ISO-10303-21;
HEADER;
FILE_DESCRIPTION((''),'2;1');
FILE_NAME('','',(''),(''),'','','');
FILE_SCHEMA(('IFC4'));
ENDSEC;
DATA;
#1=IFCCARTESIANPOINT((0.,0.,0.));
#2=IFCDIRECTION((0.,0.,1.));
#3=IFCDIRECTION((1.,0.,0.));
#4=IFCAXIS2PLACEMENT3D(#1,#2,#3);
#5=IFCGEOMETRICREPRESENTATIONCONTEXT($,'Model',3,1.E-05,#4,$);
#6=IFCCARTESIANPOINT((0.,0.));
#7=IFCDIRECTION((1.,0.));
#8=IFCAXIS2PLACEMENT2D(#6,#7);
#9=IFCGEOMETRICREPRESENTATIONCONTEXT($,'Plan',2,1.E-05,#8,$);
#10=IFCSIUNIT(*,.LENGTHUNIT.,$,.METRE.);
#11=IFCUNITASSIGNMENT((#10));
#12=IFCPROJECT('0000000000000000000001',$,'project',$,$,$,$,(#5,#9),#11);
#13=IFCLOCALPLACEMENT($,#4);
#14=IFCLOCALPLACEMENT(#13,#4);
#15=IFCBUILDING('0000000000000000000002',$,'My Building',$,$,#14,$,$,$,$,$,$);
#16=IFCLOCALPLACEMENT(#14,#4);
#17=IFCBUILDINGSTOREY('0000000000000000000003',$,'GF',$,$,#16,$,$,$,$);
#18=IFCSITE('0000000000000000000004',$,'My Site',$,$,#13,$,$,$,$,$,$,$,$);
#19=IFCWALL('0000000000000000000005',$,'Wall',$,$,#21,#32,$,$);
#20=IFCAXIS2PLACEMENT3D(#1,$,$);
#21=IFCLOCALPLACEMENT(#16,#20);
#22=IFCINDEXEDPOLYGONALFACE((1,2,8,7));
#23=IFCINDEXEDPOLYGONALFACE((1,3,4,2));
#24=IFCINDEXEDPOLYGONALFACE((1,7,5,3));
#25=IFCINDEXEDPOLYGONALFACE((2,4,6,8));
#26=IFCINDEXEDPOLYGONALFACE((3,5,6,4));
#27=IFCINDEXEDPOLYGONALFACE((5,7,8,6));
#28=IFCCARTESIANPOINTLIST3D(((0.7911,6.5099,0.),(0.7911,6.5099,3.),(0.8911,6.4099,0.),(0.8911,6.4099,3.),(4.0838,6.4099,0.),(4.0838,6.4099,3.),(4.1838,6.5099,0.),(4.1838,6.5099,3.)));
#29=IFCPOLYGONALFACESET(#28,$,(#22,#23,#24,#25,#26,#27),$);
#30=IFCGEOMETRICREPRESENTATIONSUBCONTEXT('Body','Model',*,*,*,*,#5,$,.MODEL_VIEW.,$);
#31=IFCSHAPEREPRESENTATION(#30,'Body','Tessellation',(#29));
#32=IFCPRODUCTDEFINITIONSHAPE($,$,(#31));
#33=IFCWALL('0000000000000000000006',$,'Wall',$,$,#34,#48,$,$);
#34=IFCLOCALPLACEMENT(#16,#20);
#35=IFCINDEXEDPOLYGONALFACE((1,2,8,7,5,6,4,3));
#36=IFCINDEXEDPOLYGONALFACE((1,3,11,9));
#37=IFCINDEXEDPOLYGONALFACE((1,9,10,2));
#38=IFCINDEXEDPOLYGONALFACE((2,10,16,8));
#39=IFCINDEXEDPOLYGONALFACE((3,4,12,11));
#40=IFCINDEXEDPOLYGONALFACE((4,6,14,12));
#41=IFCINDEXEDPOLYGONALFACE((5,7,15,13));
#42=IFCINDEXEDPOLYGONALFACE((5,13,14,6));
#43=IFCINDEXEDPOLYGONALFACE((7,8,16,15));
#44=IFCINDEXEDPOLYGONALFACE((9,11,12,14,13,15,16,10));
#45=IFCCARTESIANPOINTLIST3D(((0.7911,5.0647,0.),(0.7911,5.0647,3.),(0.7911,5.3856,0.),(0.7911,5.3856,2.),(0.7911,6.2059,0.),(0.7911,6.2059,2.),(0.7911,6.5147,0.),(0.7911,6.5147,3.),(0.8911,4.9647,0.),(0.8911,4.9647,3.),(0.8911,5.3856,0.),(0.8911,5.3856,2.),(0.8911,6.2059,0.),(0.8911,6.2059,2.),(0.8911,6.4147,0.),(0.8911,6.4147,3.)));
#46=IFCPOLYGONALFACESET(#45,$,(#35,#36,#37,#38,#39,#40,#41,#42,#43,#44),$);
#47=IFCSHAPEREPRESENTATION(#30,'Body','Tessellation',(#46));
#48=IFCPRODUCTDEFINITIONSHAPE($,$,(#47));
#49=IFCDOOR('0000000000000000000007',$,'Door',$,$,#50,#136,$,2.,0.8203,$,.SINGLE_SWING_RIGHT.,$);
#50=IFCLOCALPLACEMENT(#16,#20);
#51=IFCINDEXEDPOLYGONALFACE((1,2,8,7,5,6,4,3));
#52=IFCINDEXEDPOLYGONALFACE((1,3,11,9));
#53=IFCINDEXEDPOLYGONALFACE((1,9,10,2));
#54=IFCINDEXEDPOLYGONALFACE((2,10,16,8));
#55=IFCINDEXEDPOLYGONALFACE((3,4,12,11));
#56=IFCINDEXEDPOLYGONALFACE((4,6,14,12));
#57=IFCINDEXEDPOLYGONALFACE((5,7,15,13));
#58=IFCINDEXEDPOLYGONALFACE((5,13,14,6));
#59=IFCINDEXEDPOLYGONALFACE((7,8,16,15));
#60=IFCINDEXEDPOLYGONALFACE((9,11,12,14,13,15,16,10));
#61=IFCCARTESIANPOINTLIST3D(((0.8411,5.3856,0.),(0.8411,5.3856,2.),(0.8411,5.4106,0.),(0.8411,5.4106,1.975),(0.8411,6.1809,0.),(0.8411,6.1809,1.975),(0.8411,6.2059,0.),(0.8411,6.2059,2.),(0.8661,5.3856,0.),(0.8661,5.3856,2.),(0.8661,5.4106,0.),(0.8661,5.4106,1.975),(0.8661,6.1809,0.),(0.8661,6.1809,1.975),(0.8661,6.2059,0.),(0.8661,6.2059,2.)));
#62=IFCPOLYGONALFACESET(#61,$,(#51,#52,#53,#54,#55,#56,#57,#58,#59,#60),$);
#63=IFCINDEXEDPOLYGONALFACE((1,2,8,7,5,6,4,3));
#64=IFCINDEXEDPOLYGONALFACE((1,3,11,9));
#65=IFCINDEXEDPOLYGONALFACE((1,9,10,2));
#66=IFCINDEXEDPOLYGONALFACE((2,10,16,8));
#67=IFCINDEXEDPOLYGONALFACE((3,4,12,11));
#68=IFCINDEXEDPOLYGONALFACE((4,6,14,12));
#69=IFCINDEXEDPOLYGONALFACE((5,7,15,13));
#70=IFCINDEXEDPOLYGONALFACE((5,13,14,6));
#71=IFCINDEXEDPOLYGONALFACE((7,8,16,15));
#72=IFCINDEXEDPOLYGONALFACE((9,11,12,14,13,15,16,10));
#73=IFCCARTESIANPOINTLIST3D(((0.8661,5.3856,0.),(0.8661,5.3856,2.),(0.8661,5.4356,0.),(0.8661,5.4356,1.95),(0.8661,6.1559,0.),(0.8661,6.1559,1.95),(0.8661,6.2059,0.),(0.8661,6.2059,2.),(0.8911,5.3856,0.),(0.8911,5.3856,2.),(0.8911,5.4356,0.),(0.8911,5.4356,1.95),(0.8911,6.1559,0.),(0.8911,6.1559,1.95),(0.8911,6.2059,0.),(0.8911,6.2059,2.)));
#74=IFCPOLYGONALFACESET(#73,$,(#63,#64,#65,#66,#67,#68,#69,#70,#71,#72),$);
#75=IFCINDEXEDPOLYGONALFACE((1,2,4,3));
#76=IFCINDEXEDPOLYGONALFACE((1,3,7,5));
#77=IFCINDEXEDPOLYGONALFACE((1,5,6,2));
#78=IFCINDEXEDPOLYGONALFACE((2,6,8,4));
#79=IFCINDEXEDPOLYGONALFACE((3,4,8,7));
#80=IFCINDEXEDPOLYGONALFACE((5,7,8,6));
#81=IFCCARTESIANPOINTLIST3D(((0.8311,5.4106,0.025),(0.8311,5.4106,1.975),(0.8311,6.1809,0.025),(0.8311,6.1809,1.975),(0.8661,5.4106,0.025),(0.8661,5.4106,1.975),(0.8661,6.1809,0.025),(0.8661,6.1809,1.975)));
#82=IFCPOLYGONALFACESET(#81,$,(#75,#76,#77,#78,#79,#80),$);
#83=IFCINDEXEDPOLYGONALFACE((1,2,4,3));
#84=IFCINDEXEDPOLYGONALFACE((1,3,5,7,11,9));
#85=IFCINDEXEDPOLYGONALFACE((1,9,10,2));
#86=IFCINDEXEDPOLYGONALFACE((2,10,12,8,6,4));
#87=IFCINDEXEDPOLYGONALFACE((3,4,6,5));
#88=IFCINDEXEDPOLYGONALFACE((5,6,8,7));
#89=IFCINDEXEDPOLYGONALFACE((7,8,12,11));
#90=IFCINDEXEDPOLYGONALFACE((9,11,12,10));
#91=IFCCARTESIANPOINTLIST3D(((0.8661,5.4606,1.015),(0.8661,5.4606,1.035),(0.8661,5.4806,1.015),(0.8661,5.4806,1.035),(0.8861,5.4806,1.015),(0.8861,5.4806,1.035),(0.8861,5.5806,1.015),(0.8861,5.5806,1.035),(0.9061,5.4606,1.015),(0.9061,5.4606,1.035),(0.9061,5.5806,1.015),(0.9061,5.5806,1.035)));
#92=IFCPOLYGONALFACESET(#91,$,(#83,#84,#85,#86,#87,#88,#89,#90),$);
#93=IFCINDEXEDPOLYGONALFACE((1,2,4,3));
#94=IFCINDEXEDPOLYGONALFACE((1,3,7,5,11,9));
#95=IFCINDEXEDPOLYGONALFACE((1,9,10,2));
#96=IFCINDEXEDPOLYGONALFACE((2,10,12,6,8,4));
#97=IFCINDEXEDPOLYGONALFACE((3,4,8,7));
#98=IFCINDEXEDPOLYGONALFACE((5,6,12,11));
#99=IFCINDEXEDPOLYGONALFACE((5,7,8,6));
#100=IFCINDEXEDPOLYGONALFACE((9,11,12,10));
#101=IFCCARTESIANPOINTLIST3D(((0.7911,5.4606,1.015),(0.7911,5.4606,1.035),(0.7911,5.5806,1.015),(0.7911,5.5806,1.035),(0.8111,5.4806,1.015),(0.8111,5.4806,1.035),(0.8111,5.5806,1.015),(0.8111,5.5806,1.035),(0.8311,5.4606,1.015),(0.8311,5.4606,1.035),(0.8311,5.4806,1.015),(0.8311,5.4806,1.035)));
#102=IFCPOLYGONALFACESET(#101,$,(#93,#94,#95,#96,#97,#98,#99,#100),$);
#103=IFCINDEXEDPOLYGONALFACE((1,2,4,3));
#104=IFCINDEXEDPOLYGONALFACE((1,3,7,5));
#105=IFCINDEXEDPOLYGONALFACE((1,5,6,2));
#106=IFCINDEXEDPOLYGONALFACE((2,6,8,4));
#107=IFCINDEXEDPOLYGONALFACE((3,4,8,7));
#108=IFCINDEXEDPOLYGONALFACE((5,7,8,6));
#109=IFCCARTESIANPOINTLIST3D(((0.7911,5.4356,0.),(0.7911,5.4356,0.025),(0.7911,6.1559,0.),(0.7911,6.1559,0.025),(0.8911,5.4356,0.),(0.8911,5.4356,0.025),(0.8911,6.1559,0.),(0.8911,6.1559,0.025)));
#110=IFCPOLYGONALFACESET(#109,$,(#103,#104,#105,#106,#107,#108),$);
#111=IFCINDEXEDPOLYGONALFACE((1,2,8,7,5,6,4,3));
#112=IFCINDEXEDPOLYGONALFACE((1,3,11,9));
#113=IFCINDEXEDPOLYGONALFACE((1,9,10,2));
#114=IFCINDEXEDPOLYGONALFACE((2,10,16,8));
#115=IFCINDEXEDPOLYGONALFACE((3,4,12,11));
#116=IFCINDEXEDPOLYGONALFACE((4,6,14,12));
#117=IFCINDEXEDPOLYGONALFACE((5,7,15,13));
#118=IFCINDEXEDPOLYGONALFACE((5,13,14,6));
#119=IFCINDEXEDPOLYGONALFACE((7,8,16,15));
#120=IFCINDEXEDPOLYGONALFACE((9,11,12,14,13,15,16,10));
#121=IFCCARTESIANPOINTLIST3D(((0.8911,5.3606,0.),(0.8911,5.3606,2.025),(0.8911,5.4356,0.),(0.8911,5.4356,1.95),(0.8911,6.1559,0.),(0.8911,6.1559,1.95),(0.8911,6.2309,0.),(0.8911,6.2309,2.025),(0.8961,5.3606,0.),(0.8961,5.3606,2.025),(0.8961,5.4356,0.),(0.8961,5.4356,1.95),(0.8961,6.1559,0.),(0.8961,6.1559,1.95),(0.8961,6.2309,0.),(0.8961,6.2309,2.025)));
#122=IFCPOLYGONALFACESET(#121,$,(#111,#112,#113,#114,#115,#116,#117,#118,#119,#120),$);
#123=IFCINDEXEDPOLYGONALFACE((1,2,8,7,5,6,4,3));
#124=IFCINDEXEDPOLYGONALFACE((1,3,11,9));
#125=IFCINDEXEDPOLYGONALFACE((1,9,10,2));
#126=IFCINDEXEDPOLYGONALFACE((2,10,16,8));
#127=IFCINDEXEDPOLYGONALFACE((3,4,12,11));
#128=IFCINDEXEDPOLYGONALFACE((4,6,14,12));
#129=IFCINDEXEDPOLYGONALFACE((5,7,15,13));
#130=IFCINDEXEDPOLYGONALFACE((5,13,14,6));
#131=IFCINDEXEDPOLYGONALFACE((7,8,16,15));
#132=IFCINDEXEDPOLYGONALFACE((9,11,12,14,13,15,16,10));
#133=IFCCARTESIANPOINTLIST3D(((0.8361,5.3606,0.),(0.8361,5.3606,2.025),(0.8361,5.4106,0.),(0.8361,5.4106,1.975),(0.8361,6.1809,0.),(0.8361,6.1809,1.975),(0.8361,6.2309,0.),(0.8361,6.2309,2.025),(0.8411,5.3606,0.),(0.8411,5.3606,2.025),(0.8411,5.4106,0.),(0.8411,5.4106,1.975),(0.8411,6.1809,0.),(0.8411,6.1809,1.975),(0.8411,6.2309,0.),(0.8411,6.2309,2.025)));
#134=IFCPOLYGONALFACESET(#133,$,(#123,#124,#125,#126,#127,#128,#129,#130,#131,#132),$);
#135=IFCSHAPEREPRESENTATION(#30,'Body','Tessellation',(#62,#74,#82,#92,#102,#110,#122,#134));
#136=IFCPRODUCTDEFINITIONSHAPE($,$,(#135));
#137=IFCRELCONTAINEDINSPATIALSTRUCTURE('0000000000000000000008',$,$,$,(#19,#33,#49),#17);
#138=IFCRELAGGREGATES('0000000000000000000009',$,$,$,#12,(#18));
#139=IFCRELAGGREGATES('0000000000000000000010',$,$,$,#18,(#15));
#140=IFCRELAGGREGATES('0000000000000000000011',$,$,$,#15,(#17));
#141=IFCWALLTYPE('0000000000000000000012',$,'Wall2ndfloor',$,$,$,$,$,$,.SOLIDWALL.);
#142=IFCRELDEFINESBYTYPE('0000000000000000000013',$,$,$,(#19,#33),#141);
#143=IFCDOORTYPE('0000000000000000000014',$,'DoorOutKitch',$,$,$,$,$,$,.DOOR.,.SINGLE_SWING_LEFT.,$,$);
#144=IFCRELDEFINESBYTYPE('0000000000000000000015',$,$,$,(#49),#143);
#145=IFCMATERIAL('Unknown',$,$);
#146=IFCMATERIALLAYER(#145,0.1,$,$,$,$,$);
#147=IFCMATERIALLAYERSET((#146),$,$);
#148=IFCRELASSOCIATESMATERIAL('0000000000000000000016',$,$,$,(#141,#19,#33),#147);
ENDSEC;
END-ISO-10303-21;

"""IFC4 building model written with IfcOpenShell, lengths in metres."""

from ifc_helpers import new_model, entity, si_unit, frame, origin_with_axes, origin_2d_with_axis, place, context, subcontext, project, spatial, line, indexed_curve, outline, extrude, shape, source, transform, mapped, material, layer, layer_set, layer_usage, type_object, type_shapes, element, fill, save


model = new_model("IFC4")

# Units and contexts
model_context = context("Model", 3, precision=1e-05, world=origin_with_axes())
plan_context = context("Plan", 2, precision=1e-05, world=origin_2d_with_axis())
body_context_1 = subcontext(model_context, "Body", "Model", "MODEL_VIEW")
body_context_2 = subcontext(plan_context, "Body", "Plan", "PLAN_VIEW")
ifc_project = project(units=[si_unit("LENGTHUNIT", "METRE")], contexts=[model_context, plan_context])

# Site, building, storey
site_placement = place(None, origin_with_axes())
site = spatial("IfcSite", under=ifc_project, at=site_placement, Name="My Site")
building_placement = place(site_placement, origin_with_axes())
building = spatial("IfcBuilding", under=site, at=building_placement, Name="My Building")
storey_placement = place(building_placement, origin_with_axes())
storey = spatial("IfcBuildingStorey", under=building, at=storey_placement, Name="GF")

# Shared definitions
ifc_material = material(Name="Unknown")

# Wall
ifc_layer = layer(ifc_material, 0.1)
ifc_layer_set = layer_set([ifc_layer])
ifc_layer_usage_1 = layer_usage(ifc_layer_set, "AXIS2", "POSITIVE", 0.0)
wall_type = type_object("IfcWallType", Name="Wall2ndfloor", PredefinedType="SOLIDWALL", material=ifc_layer_set)
wall_1_placement = place(storey_placement, frame((4.1838, 6.5099, 0.0), z_axis=(0.0, 0.0, 1.0), x_axis=(-1.0, 0.0, 0.0)))
element("IfcWall", 1, at=wall_1_placement, inside=storey, type_object=wall_type, material=ifc_layer_usage_1, Name="Wall", context=body_context_1, shape_type="SweptSolid", body=[
    extrude(outline(indexed_curve([(0.0, 0.0), (0.1, 0.1), (3.2926, 0.1), (3.3926, 0.0)], segments=[line(1, 2, 3, 4, 1)])), origin_with_axes(), (0.0, 0.0, 1.0), 3.0),
])

# Wall, opening, door
ifc_layer_usage_2 = layer_usage(ifc_layer_set, "AXIS2", "POSITIVE", 0.0)
wall_2_placement = place(storey_placement, frame((0.7911, 6.5147, 0.0), z_axis=(0.0, 0.0, 1.0), x_axis=(0.0, -1.0, 0.0)))
wall_2 = element("IfcWall", 2, at=wall_2_placement, inside=storey, type_object=wall_type, material=ifc_layer_usage_2, Name="Wall", context=body_context_1, shape_type="SweptSolid", body=[
    extrude(outline(indexed_curve([(0.0, 0.0), (0.1, 0.1), (1.55, 0.1), (1.45, 0.0)], segments=[line(1, 2, 3, 4, 1)])), origin_with_axes(), (0.0, 0.0, 1.0), 3.0),
])
shared_shape_1 = source(origin_with_axes(), body_context_1, "Body", "SweptSolid", [
    extrude(outline(indexed_curve([(0.0, 0.0), (0.8203, 0.0), (0.8203, 2.0), (0.0, 2.0)], segments=[line(1, 2, 3, 4, 1)])), frame((0.0, -0.6, 0.0), z_axis=(0.0, -1.0, 0.0), x_axis=(1.0, 0.0, 0.0)), (0.0, 0.0, -1.0), 1.2),
])
opening_1_placement = place(wall_2_placement, frame((1.1291, 0.1, 0.0), z_axis=(0.0, 0.0, 1.0), x_axis=(-1.0, 0.0, 0.0)))
opening_1 = element("IfcOpeningElement", 3, at=opening_1_placement, cuts=wall_2, PredefinedType="OPENING", context=body_context_1, shape_type="MappedRepresentation", body=[
    mapped(shared_shape_1, transform((0.0, 0.0, 0.0), x_axis=(1.0, 0.0, 0.0), y_axis=(0.0, 1.0, 0.0), z_axis=(0.0, 0.0, 1.0), scale=1.0)),
])
door_type_1 = type_object("IfcDoorType", Name="DoorOutKitch", OperationType="SINGLE_SWING_LEFT", PredefinedType="DOOR")
shared_shape_2 = source(origin_with_axes(), body_context_1, "Body", "SweptSolid", [
    extrude(outline(indexed_curve([(0.0, 0.0), (0.0, 2.0), (0.8203, 2.0), (0.8203, 0.0), (0.7953, 0.0), (0.7953, 1.975), (0.025, 1.975), (0.025, 0.0)], segments=[line(1, 2, 3, 4, 5, 6, 7, 8, 1)])), frame((0.0, 0.025, 0.0), z_axis=(0.0, -1.0, 0.0), x_axis=(1.0, 0.0, 0.0)), (0.0, 0.0, -1.0), 0.025),
    extrude(outline(indexed_curve([(0.0, 0.0), (0.0, 2.0), (0.8203, 2.0), (0.8203, 0.0), (0.7703, 0.0), (0.7703, 1.95), (0.05, 1.95), (0.05, 0.0)], segments=[line(1, 2, 3, 4, 5, 6, 7, 8, 1)])), frame((0.0, 0.0, 0.0), z_axis=(0.0, -1.0, 0.0), x_axis=(1.0, 0.0, 0.0)), (0.0, 0.0, -1.0), 0.025),
    extrude(outline(indexed_curve([(0.0, 0.0), (0.7703, 0.0), (0.7703, 0.035), (0.0, 0.035)], segments=[line(1, 2, 3, 4, 1)])), frame((0.025, 0.025, 0.025), z_axis=(0.0, 0.0, 1.0), x_axis=(1.0, 0.0, 0.0)), (0.0, 0.0, 1.0), 1.95),
    extrude(outline(indexed_curve([(0.0, 0.0), (0.0, -0.04), (0.12, -0.04), (0.12, -0.02), (0.02, -0.02), (0.02, 0.0)], segments=[line(1, 2, 3, 4, 5, 6, 1)])), frame((0.075, 0.025, 1.015), z_axis=(0.0, 0.0, 1.0), x_axis=(1.0, 0.0, 0.0)), (0.0, 0.0, 1.0), 0.02),
    extrude(outline(indexed_curve([(0.0, 0.0), (0.0, 0.04), (0.12, 0.04), (0.12, 0.02), (0.02, 0.02), (0.02, 0.0)], segments=[line(1, 2, 3, 4, 5, 6, 1)])), frame((0.075, 0.06, 1.015), z_axis=(0.0, 0.0, 1.0), x_axis=(1.0, 0.0, 0.0)), (0.0, 0.0, 1.0), 0.02),
    extrude(outline(indexed_curve([(0.0, 0.0), (0.7203, 0.0), (0.7203, 0.1), (0.0, 0.1)], segments=[line(1, 2, 3, 4, 1)])), frame((0.05, 0.0, 0.0), z_axis=(0.0, 0.0, 1.0), x_axis=(1.0, 0.0, 0.0)), (0.0, 0.0, 1.0), 0.025),
    extrude(outline(indexed_curve([(0.0, 0.0), (0.0, 2.025), (0.8703, 2.025), (0.8703, 0.0), (0.7953, 0.0), (0.7953, 1.95), (0.075, 1.95), (0.075, 0.0)], segments=[line(1, 2, 3, 4, 5, 6, 7, 8, 1)])), frame((-0.025, -0.005, 0.0), z_axis=(0.0, -1.0, 0.0), x_axis=(1.0, 0.0, 0.0)), (0.0, 0.0, -1.0), 0.005),
    extrude(outline(indexed_curve([(0.0, 0.0), (0.0, 2.025), (0.8703, 2.025), (0.8703, 0.0), (0.8203, 0.0), (0.8203, 1.975), (0.05, 1.975), (0.05, 0.0)], segments=[line(1, 2, 3, 4, 5, 6, 7, 8, 1)])), frame((-0.025, 0.05, 0.0), z_axis=(0.0, -1.0, 0.0), x_axis=(1.0, 0.0, 0.0)), (0.0, 0.0, -1.0), 0.005),
])
shared_shape_3 = source(origin_with_axes(), body_context_2, "Body", "Curve2D", [
    entity("IfcIndexedPolyCurve", entity("IfcCartesianPointList2D", [[0.0, 0.0], [0.0, 0.05], [0.025, 0.05], [0.025, 0.025], [0.05, 0.025], [0.05, 0.0]]), [entity("IfcLineIndex", [1, 2, 3, 4, 5, 6, 1])]),
    entity("IfcIndexedPolyCurve", entity("IfcCartesianPointList2D", [[0.8203, 0.0], [0.8203, 0.05], [0.7953, 0.05], [0.7953, 0.025], [0.7703, 0.025], [0.7703, 0.0]]), [entity("IfcLineIndex", [1, 2, 3, 4, 5, 6, 1])]),
    entity("IfcTrimmedCurve", entity("IfcEllipse", entity("IfcAxis2Placement2D", entity("IfcCartesianPoint", [0.7603, 0.05]), entity("IfcDirection", [1.0, 0.0])), 0.7353, 0.7703), [entity("IfcCartesianPoint", [0.7603, 0.8203])], [entity("IfcCartesianPoint", [0.025, 0.05])], True, "CARTESIAN"),
    entity("IfcIndexedPolyCurve", entity("IfcCartesianPointList2D", [[0.7953, 0.05], [0.7603, 0.05], [0.7603, 0.8203], [0.7953, 0.8203]]), [entity("IfcLineIndex", [1, 2, 3, 4, 1])]),
])
type_shapes(door_type_1, [shared_shape_2, shared_shape_3])
door_1_placement = place(opening_1_placement, frame((0.0, 0.0, 0.0), z_axis=(0.0, 0.0, 1.0), x_axis=(1.0, 0.0, 0.0)))
door_1 = element("IfcDoor", 4, at=door_1_placement, inside=storey, type_object=door_type_1, Name="Door", OperationType="SINGLE_SWING_RIGHT", OverallHeight=2.0, OverallWidth=0.8203, shapes=[
    shape(body_context_1, "Body", "MappedRepresentation", [mapped(shared_shape_2, transform((0.0, 0.0, 0.0), x_axis=(1.0, 0.0, 0.0), y_axis=(0.0, 1.0, 0.0), z_axis=(0.0, 0.0, 1.0), scale=1.0))]),
    shape(body_context_2, "Body", "MappedRepresentation", [mapped(shared_shape_3, transform((0.0, 0.0, 0.0), x_axis=(1.0, 0.0, 0.0), y_axis=(0.0, 1.0, 0.0), z_axis=(0.0, 0.0, 1.0), scale=1.0))]),
])
fill(opening_1, door_1)

save(model, "model.ifc")
